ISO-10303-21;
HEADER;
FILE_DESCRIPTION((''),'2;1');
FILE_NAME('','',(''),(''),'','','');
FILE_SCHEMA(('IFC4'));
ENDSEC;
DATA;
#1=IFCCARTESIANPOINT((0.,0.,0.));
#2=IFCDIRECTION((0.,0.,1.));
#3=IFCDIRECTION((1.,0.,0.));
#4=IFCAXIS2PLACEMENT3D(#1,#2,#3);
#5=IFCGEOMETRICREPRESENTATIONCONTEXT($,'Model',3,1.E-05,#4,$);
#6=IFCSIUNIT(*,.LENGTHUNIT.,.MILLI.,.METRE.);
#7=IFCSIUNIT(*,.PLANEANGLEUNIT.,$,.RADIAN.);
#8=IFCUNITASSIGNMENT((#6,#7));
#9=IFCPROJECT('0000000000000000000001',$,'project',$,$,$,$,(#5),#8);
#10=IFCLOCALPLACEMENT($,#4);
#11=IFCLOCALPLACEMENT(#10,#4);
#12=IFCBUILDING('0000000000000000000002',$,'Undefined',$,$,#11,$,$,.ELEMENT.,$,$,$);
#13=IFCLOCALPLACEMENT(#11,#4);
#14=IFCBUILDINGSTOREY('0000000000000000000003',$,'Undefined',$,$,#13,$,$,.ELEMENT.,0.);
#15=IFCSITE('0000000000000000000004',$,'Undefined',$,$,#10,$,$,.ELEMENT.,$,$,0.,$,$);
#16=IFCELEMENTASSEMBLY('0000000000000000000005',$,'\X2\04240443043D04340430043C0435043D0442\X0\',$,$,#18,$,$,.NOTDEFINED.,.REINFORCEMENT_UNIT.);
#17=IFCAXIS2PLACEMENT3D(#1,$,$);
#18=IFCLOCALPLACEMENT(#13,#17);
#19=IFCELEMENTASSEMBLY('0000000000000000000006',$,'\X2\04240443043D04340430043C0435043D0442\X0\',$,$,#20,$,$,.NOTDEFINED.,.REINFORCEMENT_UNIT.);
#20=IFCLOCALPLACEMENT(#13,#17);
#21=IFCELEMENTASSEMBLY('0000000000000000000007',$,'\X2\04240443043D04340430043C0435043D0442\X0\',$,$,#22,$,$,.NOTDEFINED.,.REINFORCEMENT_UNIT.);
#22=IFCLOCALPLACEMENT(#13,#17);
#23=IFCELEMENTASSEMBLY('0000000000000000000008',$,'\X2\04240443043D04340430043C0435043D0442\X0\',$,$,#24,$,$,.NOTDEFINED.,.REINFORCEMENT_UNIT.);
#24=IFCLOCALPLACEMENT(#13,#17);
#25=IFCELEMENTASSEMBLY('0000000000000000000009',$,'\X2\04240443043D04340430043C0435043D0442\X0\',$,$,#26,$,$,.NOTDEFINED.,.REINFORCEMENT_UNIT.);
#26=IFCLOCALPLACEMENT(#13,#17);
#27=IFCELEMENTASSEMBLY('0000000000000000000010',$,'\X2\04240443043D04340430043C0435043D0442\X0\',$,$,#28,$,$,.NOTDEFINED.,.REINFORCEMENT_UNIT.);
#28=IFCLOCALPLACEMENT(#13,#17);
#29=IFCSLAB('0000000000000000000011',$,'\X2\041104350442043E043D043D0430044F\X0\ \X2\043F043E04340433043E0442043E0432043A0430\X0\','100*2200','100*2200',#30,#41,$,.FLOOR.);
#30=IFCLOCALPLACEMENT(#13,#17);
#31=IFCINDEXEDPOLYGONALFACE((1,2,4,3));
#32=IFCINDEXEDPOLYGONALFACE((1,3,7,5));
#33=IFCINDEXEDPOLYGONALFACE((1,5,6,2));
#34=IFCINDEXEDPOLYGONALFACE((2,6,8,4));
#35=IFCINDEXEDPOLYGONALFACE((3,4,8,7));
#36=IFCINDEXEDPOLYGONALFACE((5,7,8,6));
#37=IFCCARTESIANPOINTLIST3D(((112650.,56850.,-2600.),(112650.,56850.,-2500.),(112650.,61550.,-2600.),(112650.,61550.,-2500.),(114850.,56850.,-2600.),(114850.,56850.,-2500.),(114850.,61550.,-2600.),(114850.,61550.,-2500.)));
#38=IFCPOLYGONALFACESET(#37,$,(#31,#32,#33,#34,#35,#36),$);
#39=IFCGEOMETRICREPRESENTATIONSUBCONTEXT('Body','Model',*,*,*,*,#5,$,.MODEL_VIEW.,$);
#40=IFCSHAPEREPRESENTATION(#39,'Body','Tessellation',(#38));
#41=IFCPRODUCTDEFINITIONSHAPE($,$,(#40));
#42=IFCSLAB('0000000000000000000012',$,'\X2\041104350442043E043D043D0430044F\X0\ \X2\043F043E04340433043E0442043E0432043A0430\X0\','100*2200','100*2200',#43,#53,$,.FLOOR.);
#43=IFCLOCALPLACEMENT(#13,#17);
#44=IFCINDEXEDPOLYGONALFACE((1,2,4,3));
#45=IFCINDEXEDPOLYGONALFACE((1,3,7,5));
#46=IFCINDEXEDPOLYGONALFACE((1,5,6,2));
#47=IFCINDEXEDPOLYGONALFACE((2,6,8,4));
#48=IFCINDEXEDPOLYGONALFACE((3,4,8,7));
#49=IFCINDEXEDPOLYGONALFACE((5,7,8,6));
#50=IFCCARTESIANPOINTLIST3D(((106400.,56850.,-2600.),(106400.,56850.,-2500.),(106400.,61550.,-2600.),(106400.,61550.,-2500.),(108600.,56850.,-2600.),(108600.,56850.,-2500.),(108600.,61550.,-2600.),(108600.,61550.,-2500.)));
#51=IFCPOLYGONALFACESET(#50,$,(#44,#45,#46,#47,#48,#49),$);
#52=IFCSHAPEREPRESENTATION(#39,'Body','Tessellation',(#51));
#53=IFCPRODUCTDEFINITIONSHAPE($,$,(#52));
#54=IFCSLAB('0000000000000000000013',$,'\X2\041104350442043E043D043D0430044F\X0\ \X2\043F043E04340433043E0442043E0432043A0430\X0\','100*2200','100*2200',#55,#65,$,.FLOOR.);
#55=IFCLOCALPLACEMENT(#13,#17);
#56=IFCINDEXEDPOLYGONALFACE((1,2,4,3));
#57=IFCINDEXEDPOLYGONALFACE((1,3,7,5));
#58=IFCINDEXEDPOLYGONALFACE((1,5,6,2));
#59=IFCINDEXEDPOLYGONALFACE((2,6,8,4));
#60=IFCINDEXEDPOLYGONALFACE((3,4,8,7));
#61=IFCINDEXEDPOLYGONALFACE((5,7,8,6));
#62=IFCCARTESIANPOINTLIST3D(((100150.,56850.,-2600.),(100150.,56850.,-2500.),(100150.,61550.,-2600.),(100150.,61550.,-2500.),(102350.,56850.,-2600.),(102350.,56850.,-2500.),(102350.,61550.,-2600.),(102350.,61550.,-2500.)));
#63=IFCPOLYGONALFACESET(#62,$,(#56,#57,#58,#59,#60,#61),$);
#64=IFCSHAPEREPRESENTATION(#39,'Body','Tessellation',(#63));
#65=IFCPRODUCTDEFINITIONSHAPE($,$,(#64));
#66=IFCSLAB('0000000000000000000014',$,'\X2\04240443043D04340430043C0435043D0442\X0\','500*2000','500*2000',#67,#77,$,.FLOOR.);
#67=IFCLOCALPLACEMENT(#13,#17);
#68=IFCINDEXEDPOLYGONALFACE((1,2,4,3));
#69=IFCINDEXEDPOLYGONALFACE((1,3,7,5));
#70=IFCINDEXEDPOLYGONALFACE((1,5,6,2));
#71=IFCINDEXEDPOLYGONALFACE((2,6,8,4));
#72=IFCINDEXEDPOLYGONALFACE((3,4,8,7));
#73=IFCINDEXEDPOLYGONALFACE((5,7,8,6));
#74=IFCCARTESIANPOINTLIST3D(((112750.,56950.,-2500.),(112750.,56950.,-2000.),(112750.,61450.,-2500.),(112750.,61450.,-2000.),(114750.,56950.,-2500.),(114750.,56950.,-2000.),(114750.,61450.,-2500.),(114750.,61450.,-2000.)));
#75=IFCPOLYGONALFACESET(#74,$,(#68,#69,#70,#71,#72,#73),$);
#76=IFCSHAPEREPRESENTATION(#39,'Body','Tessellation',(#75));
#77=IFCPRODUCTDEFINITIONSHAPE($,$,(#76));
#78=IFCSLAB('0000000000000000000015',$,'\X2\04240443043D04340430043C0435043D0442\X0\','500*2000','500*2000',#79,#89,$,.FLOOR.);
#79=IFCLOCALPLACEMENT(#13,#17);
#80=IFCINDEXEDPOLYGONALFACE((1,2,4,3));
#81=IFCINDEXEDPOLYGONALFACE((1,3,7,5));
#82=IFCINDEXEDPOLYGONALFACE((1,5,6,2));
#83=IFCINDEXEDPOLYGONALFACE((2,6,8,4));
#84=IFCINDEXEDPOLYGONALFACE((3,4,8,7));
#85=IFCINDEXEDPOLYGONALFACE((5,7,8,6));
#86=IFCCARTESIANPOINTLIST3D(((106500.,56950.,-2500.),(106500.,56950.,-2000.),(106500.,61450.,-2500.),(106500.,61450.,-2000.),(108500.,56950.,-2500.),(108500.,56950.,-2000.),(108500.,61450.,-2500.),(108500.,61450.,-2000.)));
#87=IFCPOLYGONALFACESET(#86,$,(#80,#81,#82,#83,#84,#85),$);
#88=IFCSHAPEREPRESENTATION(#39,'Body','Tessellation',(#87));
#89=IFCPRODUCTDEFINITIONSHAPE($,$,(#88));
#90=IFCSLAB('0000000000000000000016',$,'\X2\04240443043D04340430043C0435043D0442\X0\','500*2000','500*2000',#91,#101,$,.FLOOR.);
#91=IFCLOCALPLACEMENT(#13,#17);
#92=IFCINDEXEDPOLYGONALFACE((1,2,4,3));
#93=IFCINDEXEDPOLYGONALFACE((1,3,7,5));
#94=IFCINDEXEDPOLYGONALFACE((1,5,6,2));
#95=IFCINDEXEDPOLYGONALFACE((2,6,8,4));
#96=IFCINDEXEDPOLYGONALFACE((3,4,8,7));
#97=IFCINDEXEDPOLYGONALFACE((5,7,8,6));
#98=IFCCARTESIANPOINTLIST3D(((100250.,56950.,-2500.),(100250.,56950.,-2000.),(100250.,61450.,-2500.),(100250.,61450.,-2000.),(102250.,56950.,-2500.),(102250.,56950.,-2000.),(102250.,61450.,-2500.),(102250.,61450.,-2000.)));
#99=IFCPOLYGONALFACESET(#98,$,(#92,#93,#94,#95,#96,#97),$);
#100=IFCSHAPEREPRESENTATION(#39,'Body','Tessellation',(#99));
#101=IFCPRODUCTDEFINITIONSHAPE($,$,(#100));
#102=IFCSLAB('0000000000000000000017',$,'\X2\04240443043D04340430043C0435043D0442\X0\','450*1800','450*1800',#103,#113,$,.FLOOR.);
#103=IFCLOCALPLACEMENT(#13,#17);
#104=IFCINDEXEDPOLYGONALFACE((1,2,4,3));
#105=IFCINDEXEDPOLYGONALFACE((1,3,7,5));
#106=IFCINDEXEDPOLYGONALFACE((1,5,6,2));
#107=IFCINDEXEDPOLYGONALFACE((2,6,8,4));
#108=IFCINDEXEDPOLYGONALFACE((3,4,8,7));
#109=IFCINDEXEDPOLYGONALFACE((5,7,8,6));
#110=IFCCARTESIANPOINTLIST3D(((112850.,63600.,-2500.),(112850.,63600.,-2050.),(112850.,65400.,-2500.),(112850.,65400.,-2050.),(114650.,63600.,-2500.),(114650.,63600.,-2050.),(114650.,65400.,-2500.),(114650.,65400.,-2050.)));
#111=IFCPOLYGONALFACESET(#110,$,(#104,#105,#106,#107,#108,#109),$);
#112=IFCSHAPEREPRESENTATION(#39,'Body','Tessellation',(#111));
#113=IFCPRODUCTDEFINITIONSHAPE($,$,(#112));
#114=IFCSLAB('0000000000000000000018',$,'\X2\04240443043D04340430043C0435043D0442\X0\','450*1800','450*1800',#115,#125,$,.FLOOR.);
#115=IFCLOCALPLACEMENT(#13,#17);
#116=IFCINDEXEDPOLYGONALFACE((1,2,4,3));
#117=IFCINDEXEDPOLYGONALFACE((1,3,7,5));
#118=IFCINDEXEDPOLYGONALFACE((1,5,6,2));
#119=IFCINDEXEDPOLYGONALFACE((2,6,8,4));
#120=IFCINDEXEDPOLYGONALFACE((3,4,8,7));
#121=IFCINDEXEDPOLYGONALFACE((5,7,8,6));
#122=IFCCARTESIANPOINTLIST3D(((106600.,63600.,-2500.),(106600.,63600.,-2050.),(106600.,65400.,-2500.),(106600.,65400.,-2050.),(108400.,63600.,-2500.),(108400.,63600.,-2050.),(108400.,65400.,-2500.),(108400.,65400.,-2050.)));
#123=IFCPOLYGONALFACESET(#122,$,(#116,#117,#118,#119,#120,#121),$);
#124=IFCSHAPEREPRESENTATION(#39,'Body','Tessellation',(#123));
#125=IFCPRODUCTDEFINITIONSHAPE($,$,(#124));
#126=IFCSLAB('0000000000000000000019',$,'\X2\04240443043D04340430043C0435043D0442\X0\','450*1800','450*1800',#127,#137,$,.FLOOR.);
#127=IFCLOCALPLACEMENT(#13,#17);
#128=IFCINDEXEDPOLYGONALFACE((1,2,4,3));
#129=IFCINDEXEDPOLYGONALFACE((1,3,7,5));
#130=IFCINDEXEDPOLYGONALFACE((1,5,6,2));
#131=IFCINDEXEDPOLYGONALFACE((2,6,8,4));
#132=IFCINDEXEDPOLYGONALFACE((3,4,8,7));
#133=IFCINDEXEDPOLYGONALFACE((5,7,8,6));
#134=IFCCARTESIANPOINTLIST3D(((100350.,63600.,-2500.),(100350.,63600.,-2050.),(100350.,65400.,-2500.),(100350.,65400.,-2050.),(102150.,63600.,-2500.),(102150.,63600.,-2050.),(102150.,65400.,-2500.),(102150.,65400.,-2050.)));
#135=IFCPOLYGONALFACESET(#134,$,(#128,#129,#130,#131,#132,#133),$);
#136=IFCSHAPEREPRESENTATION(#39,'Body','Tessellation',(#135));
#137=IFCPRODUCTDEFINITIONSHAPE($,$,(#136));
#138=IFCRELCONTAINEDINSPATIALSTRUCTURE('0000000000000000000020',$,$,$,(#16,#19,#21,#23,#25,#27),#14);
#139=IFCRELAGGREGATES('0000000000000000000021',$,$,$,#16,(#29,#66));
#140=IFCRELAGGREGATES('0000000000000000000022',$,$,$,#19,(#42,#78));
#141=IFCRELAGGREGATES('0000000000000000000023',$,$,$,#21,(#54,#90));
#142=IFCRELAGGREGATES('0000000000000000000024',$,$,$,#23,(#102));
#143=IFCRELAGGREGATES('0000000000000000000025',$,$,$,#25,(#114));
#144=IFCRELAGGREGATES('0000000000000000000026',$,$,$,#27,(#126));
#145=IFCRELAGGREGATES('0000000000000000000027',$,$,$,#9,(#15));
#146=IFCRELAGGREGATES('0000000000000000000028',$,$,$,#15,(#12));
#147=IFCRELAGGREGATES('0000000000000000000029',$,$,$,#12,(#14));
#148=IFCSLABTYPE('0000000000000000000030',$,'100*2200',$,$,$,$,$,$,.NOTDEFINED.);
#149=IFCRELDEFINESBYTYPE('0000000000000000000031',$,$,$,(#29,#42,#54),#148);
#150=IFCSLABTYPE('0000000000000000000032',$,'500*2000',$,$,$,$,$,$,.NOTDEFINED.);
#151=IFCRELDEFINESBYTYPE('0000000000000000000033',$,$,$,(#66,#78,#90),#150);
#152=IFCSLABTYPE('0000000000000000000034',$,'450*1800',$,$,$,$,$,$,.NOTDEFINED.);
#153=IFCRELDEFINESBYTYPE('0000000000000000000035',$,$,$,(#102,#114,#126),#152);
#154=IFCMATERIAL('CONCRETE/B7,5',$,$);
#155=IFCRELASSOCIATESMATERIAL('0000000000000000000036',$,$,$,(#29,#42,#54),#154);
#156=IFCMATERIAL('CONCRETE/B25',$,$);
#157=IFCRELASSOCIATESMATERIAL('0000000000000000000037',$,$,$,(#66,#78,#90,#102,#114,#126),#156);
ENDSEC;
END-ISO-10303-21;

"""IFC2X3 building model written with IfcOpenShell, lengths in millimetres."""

from ifc_helpers import new_model, si_unit, frame, origin_with_axes, place, context, subcontext, project, spatial, polyline, outline, extrude, material, type_object, element, aggregate, save


model = new_model("IFC2X3")

# Units and contexts
model_context = context("Model", 3, precision=1e-05, world=origin_with_axes())
body_context = subcontext(model_context, "Body", "Model", "MODEL_VIEW")
ifc_project = project(units=[si_unit("LENGTHUNIT", "METRE", prefix="MILLI"), si_unit("PLANEANGLEUNIT", "RADIAN")], contexts=[model_context])

# Site, building, storey
site_placement = place(None, origin_with_axes())
site = spatial("IfcSite", under=ifc_project, at=site_placement, Name="Undefined", CompositionType="ELEMENT", RefElevation=0.0)
building_placement = place(site_placement, origin_with_axes())
building = spatial("IfcBuilding", under=site, at=building_placement, Name="Undefined", CompositionType="ELEMENT")
storey_placement = place(building_placement, origin_with_axes())
storey = spatial("IfcBuildingStorey", under=building, at=storey_placement, Name="Undefined", CompositionType="ELEMENT", Elevation=0.0)

# Element assemblies
assembly_1_placement = place(storey_placement, origin_with_axes())
assembly_1 = element("IfcElementAssembly", 1, at=assembly_1_placement, inside=storey, Name="Фундамент", AssemblyPlace="NOTDEFINED", PredefinedType="REINFORCEMENT_UNIT")
ifc_material_1 = material(Name="CONCRETE/B25")
assembly_2_placement = place(storey_placement, origin_with_axes())
assembly_2 = element("IfcElementAssembly", 2, at=assembly_2_placement, inside=storey, Name="Фундамент", AssemblyPlace="NOTDEFINED", PredefinedType="REINFORCEMENT_UNIT")
assembly_3_placement = place(storey_placement, origin_with_axes())
assembly_3 = element("IfcElementAssembly", 3, at=assembly_3_placement, inside=storey, Name="Фундамент", AssemblyPlace="NOTDEFINED", PredefinedType="REINFORCEMENT_UNIT")

# Element assemblies
assembly_4_placement = place(storey_placement, origin_with_axes())
assembly_4 = element("IfcElementAssembly", 4, at=assembly_4_placement, inside=storey, Name="Фундамент", AssemblyPlace="NOTDEFINED", PredefinedType="REINFORCEMENT_UNIT")
assembly_5_placement = place(storey_placement, origin_with_axes())
assembly_5 = element("IfcElementAssembly", 5, at=assembly_5_placement, inside=storey, Name="Фундамент", AssemblyPlace="NOTDEFINED", PredefinedType="REINFORCEMENT_UNIT")
assembly_6_placement = place(storey_placement, origin_with_axes())
assembly_6 = element("IfcElementAssembly", 6, at=assembly_6_placement, inside=storey, Name="Фундамент", AssemblyPlace="NOTDEFINED", PredefinedType="REINFORCEMENT_UNIT")

# Slabs
ifc_material_2 = material(Name="CONCRETE/B7,5")
slab_type_1 = type_object("IfcSlabType", Name="100*2200", PredefinedType="NOTDEFINED")
slab_1_placement = place(assembly_1_placement, frame((112650.0, 61550.0, -2550.0), z_axis=(0.0, 0.0, 1.0), x_axis=(0.0, -1.0, 0.0)))
slab_1 = element("IfcSlab", 7, at=slab_1_placement, type_object=slab_type_1, material=ifc_material_2, Name="Бетонная подготовка", Description="100*2200", ObjectType="100*2200", PredefinedType="FLOOR", context=body_context, shape_type="SweptSolid", body=[
    extrude(outline(polyline([(0.0, 0.0), (4700.0, 0.0), (4700.0, 2200.0), (0.0, 2200.0), (0.0, 0.0)])), frame((0.0, 0.0, -50.0), z_axis=(0.0, 0.0, 1.0), x_axis=(1.0, 0.0, 0.0)), (0.0, 0.0, 1.0), 100.0),
])
slab_2_placement = place(assembly_2_placement, frame((106400.0, 61550.0, -2550.0), z_axis=(0.0, 0.0, 1.0), x_axis=(0.0, -1.0, 0.0)))
slab_2 = element("IfcSlab", 8, at=slab_2_placement, type_object=slab_type_1, material=ifc_material_2, Name="Бетонная подготовка", Description="100*2200", ObjectType="100*2200", PredefinedType="FLOOR", context=body_context, shape_type="SweptSolid", body=[
    extrude(outline(polyline([(0.0, 0.0), (4700.0, 0.0), (4700.0, 2200.0), (0.0, 2200.0), (0.0, 0.0)])), frame((0.0, 0.0, -50.0), z_axis=(0.0, 0.0, 1.0), x_axis=(1.0, 0.0, 0.0)), (0.0, 0.0, 1.0), 100.0),
])
slab_3_placement = place(assembly_3_placement, frame((100150.0, 61550.0, -2550.0), z_axis=(0.0, 0.0, 1.0), x_axis=(0.0, -1.0, 0.0)))
slab_3 = element("IfcSlab", 9, at=slab_3_placement, type_object=slab_type_1, material=ifc_material_2, Name="Бетонная подготовка", Description="100*2200", ObjectType="100*2200", PredefinedType="FLOOR", context=body_context, shape_type="SweptSolid", body=[
    extrude(outline(polyline([(0.0, 0.0), (4700.0, 0.0), (4700.0, 2200.0), (0.0, 2200.0), (0.0, 0.0)])), frame((0.0, 0.0, -50.0), z_axis=(0.0, 0.0, 1.0), x_axis=(1.0, 0.0, 0.0)), (0.0, 0.0, 1.0), 100.0),
])
slab_type_2 = type_object("IfcSlabType", Name="500*2000", PredefinedType="NOTDEFINED")
slab_4_placement = place(assembly_1_placement, frame((112750.0, 61450.0, -2250.0), z_axis=(0.0, 0.0, 1.0), x_axis=(0.0, -1.0, 0.0)))
slab_4 = element("IfcSlab", 10, at=slab_4_placement, type_object=slab_type_2, material=ifc_material_1, Name="Фундамент", Description="500*2000", ObjectType="500*2000", PredefinedType="FLOOR", context=body_context, shape_type="SweptSolid", body=[
    extrude(outline(polyline([(0.0, 0.0), (4500.0, 0.0), (4500.0, 2000.0), (0.0, 2000.0), (0.0, 0.0)])), frame((0.0, 0.0, -250.0), z_axis=(0.0, 0.0, 1.0), x_axis=(1.0, 0.0, 0.0)), (0.0, 0.0, 1.0), 500.0),
])
aggregate(assembly_1, [slab_1, slab_4])
slab_5_placement = place(assembly_2_placement, frame((106500.0, 61450.0, -2250.0), z_axis=(0.0, 0.0, 1.0), x_axis=(0.0, -1.0, 0.0)))
slab_5 = element("IfcSlab", 11, at=slab_5_placement, type_object=slab_type_2, material=ifc_material_1, Name="Фундамент", Description="500*2000", ObjectType="500*2000", PredefinedType="FLOOR", context=body_context, shape_type="SweptSolid", body=[
    extrude(outline(polyline([(0.0, 0.0), (4500.0, 0.0), (4500.0, 2000.0), (0.0, 2000.0), (0.0, 0.0)])), frame((0.0, 0.0, -250.0), z_axis=(0.0, 0.0, 1.0), x_axis=(1.0, 0.0, 0.0)), (0.0, 0.0, 1.0), 500.0),
])
aggregate(assembly_2, [slab_2, slab_5])
slab_6_placement = place(assembly_3_placement, frame((100250.0, 61450.0, -2250.0), z_axis=(0.0, 0.0, 1.0), x_axis=(0.0, -1.0, 0.0)))
slab_6 = element("IfcSlab", 12, at=slab_6_placement, type_object=slab_type_2, material=ifc_material_1, Name="Фундамент", Description="500*2000", ObjectType="500*2000", PredefinedType="FLOOR", context=body_context, shape_type="SweptSolid", body=[
    extrude(outline(polyline([(0.0, 0.0), (4500.0, 0.0), (4500.0, 2000.0), (0.0, 2000.0), (0.0, 0.0)])), frame((0.0, 0.0, -250.0), z_axis=(0.0, 0.0, 1.0), x_axis=(1.0, 0.0, 0.0)), (0.0, 0.0, 1.0), 500.0),
])
aggregate(assembly_3, [slab_3, slab_6])
slab_type_3 = type_object("IfcSlabType", Name="450*1800", PredefinedType="NOTDEFINED")
slab_7_placement = place(assembly_4_placement, frame((112850.0, 65400.0, -2275.0), z_axis=(0.0, 0.0, 1.0), x_axis=(0.0, -1.0, 0.0)))
slab_7 = element("IfcSlab", 13, at=slab_7_placement, type_object=slab_type_3, material=ifc_material_1, Name="Фундамент", Description="450*1800", ObjectType="450*1800", PredefinedType="FLOOR", context=body_context, shape_type="SweptSolid", body=[
    extrude(outline(polyline([(0.0, 0.0), (1800.0, 0.0), (1800.0, 1800.0), (0.0, 1800.0), (0.0, 0.0)])), frame((0.0, 0.0, -225.0), z_axis=(0.0, 0.0, 1.0), x_axis=(1.0, 0.0, 0.0)), (0.0, 0.0, 1.0), 450.0),
])
aggregate(assembly_4, [slab_7])
slab_8_placement = place(assembly_5_placement, frame((106600.0, 65400.0, -2275.0), z_axis=(0.0, 0.0, 1.0), x_axis=(0.0, -1.0, 0.0)))
slab_8 = element("IfcSlab", 14, at=slab_8_placement, type_object=slab_type_3, material=ifc_material_1, Name="Фундамент", Description="450*1800", ObjectType="450*1800", PredefinedType="FLOOR", context=body_context, shape_type="SweptSolid", body=[
    extrude(outline(polyline([(0.0, 0.0), (1800.0, 0.0), (1800.0, 1800.0), (0.0, 1800.0), (0.0, 0.0)])), frame((0.0, 0.0, -225.0), z_axis=(0.0, 0.0, 1.0), x_axis=(1.0, 0.0, 0.0)), (0.0, 0.0, 1.0), 450.0),
])
aggregate(assembly_5, [slab_8])
slab_9_placement = place(assembly_6_placement, frame((100350.0, 65400.0, -2275.0), z_axis=(0.0, 0.0, 1.0), x_axis=(0.0, -1.0, 0.0)))
slab_9 = element("IfcSlab", 15, at=slab_9_placement, type_object=slab_type_3, material=ifc_material_1, Name="Фундамент", Description="450*1800", ObjectType="450*1800", PredefinedType="FLOOR", context=body_context, shape_type="SweptSolid", body=[
    extrude(outline(polyline([(0.0, 0.0), (1800.0, 0.0), (1800.0, 1800.0), (0.0, 1800.0), (0.0, 0.0)])), frame((0.0, 0.0, -225.0), z_axis=(0.0, 0.0, 1.0), x_axis=(1.0, 0.0, 0.0)), (0.0, 0.0, 1.0), 450.0),
])
aggregate(assembly_6, [slab_9])

save(model, "model.ifc")
